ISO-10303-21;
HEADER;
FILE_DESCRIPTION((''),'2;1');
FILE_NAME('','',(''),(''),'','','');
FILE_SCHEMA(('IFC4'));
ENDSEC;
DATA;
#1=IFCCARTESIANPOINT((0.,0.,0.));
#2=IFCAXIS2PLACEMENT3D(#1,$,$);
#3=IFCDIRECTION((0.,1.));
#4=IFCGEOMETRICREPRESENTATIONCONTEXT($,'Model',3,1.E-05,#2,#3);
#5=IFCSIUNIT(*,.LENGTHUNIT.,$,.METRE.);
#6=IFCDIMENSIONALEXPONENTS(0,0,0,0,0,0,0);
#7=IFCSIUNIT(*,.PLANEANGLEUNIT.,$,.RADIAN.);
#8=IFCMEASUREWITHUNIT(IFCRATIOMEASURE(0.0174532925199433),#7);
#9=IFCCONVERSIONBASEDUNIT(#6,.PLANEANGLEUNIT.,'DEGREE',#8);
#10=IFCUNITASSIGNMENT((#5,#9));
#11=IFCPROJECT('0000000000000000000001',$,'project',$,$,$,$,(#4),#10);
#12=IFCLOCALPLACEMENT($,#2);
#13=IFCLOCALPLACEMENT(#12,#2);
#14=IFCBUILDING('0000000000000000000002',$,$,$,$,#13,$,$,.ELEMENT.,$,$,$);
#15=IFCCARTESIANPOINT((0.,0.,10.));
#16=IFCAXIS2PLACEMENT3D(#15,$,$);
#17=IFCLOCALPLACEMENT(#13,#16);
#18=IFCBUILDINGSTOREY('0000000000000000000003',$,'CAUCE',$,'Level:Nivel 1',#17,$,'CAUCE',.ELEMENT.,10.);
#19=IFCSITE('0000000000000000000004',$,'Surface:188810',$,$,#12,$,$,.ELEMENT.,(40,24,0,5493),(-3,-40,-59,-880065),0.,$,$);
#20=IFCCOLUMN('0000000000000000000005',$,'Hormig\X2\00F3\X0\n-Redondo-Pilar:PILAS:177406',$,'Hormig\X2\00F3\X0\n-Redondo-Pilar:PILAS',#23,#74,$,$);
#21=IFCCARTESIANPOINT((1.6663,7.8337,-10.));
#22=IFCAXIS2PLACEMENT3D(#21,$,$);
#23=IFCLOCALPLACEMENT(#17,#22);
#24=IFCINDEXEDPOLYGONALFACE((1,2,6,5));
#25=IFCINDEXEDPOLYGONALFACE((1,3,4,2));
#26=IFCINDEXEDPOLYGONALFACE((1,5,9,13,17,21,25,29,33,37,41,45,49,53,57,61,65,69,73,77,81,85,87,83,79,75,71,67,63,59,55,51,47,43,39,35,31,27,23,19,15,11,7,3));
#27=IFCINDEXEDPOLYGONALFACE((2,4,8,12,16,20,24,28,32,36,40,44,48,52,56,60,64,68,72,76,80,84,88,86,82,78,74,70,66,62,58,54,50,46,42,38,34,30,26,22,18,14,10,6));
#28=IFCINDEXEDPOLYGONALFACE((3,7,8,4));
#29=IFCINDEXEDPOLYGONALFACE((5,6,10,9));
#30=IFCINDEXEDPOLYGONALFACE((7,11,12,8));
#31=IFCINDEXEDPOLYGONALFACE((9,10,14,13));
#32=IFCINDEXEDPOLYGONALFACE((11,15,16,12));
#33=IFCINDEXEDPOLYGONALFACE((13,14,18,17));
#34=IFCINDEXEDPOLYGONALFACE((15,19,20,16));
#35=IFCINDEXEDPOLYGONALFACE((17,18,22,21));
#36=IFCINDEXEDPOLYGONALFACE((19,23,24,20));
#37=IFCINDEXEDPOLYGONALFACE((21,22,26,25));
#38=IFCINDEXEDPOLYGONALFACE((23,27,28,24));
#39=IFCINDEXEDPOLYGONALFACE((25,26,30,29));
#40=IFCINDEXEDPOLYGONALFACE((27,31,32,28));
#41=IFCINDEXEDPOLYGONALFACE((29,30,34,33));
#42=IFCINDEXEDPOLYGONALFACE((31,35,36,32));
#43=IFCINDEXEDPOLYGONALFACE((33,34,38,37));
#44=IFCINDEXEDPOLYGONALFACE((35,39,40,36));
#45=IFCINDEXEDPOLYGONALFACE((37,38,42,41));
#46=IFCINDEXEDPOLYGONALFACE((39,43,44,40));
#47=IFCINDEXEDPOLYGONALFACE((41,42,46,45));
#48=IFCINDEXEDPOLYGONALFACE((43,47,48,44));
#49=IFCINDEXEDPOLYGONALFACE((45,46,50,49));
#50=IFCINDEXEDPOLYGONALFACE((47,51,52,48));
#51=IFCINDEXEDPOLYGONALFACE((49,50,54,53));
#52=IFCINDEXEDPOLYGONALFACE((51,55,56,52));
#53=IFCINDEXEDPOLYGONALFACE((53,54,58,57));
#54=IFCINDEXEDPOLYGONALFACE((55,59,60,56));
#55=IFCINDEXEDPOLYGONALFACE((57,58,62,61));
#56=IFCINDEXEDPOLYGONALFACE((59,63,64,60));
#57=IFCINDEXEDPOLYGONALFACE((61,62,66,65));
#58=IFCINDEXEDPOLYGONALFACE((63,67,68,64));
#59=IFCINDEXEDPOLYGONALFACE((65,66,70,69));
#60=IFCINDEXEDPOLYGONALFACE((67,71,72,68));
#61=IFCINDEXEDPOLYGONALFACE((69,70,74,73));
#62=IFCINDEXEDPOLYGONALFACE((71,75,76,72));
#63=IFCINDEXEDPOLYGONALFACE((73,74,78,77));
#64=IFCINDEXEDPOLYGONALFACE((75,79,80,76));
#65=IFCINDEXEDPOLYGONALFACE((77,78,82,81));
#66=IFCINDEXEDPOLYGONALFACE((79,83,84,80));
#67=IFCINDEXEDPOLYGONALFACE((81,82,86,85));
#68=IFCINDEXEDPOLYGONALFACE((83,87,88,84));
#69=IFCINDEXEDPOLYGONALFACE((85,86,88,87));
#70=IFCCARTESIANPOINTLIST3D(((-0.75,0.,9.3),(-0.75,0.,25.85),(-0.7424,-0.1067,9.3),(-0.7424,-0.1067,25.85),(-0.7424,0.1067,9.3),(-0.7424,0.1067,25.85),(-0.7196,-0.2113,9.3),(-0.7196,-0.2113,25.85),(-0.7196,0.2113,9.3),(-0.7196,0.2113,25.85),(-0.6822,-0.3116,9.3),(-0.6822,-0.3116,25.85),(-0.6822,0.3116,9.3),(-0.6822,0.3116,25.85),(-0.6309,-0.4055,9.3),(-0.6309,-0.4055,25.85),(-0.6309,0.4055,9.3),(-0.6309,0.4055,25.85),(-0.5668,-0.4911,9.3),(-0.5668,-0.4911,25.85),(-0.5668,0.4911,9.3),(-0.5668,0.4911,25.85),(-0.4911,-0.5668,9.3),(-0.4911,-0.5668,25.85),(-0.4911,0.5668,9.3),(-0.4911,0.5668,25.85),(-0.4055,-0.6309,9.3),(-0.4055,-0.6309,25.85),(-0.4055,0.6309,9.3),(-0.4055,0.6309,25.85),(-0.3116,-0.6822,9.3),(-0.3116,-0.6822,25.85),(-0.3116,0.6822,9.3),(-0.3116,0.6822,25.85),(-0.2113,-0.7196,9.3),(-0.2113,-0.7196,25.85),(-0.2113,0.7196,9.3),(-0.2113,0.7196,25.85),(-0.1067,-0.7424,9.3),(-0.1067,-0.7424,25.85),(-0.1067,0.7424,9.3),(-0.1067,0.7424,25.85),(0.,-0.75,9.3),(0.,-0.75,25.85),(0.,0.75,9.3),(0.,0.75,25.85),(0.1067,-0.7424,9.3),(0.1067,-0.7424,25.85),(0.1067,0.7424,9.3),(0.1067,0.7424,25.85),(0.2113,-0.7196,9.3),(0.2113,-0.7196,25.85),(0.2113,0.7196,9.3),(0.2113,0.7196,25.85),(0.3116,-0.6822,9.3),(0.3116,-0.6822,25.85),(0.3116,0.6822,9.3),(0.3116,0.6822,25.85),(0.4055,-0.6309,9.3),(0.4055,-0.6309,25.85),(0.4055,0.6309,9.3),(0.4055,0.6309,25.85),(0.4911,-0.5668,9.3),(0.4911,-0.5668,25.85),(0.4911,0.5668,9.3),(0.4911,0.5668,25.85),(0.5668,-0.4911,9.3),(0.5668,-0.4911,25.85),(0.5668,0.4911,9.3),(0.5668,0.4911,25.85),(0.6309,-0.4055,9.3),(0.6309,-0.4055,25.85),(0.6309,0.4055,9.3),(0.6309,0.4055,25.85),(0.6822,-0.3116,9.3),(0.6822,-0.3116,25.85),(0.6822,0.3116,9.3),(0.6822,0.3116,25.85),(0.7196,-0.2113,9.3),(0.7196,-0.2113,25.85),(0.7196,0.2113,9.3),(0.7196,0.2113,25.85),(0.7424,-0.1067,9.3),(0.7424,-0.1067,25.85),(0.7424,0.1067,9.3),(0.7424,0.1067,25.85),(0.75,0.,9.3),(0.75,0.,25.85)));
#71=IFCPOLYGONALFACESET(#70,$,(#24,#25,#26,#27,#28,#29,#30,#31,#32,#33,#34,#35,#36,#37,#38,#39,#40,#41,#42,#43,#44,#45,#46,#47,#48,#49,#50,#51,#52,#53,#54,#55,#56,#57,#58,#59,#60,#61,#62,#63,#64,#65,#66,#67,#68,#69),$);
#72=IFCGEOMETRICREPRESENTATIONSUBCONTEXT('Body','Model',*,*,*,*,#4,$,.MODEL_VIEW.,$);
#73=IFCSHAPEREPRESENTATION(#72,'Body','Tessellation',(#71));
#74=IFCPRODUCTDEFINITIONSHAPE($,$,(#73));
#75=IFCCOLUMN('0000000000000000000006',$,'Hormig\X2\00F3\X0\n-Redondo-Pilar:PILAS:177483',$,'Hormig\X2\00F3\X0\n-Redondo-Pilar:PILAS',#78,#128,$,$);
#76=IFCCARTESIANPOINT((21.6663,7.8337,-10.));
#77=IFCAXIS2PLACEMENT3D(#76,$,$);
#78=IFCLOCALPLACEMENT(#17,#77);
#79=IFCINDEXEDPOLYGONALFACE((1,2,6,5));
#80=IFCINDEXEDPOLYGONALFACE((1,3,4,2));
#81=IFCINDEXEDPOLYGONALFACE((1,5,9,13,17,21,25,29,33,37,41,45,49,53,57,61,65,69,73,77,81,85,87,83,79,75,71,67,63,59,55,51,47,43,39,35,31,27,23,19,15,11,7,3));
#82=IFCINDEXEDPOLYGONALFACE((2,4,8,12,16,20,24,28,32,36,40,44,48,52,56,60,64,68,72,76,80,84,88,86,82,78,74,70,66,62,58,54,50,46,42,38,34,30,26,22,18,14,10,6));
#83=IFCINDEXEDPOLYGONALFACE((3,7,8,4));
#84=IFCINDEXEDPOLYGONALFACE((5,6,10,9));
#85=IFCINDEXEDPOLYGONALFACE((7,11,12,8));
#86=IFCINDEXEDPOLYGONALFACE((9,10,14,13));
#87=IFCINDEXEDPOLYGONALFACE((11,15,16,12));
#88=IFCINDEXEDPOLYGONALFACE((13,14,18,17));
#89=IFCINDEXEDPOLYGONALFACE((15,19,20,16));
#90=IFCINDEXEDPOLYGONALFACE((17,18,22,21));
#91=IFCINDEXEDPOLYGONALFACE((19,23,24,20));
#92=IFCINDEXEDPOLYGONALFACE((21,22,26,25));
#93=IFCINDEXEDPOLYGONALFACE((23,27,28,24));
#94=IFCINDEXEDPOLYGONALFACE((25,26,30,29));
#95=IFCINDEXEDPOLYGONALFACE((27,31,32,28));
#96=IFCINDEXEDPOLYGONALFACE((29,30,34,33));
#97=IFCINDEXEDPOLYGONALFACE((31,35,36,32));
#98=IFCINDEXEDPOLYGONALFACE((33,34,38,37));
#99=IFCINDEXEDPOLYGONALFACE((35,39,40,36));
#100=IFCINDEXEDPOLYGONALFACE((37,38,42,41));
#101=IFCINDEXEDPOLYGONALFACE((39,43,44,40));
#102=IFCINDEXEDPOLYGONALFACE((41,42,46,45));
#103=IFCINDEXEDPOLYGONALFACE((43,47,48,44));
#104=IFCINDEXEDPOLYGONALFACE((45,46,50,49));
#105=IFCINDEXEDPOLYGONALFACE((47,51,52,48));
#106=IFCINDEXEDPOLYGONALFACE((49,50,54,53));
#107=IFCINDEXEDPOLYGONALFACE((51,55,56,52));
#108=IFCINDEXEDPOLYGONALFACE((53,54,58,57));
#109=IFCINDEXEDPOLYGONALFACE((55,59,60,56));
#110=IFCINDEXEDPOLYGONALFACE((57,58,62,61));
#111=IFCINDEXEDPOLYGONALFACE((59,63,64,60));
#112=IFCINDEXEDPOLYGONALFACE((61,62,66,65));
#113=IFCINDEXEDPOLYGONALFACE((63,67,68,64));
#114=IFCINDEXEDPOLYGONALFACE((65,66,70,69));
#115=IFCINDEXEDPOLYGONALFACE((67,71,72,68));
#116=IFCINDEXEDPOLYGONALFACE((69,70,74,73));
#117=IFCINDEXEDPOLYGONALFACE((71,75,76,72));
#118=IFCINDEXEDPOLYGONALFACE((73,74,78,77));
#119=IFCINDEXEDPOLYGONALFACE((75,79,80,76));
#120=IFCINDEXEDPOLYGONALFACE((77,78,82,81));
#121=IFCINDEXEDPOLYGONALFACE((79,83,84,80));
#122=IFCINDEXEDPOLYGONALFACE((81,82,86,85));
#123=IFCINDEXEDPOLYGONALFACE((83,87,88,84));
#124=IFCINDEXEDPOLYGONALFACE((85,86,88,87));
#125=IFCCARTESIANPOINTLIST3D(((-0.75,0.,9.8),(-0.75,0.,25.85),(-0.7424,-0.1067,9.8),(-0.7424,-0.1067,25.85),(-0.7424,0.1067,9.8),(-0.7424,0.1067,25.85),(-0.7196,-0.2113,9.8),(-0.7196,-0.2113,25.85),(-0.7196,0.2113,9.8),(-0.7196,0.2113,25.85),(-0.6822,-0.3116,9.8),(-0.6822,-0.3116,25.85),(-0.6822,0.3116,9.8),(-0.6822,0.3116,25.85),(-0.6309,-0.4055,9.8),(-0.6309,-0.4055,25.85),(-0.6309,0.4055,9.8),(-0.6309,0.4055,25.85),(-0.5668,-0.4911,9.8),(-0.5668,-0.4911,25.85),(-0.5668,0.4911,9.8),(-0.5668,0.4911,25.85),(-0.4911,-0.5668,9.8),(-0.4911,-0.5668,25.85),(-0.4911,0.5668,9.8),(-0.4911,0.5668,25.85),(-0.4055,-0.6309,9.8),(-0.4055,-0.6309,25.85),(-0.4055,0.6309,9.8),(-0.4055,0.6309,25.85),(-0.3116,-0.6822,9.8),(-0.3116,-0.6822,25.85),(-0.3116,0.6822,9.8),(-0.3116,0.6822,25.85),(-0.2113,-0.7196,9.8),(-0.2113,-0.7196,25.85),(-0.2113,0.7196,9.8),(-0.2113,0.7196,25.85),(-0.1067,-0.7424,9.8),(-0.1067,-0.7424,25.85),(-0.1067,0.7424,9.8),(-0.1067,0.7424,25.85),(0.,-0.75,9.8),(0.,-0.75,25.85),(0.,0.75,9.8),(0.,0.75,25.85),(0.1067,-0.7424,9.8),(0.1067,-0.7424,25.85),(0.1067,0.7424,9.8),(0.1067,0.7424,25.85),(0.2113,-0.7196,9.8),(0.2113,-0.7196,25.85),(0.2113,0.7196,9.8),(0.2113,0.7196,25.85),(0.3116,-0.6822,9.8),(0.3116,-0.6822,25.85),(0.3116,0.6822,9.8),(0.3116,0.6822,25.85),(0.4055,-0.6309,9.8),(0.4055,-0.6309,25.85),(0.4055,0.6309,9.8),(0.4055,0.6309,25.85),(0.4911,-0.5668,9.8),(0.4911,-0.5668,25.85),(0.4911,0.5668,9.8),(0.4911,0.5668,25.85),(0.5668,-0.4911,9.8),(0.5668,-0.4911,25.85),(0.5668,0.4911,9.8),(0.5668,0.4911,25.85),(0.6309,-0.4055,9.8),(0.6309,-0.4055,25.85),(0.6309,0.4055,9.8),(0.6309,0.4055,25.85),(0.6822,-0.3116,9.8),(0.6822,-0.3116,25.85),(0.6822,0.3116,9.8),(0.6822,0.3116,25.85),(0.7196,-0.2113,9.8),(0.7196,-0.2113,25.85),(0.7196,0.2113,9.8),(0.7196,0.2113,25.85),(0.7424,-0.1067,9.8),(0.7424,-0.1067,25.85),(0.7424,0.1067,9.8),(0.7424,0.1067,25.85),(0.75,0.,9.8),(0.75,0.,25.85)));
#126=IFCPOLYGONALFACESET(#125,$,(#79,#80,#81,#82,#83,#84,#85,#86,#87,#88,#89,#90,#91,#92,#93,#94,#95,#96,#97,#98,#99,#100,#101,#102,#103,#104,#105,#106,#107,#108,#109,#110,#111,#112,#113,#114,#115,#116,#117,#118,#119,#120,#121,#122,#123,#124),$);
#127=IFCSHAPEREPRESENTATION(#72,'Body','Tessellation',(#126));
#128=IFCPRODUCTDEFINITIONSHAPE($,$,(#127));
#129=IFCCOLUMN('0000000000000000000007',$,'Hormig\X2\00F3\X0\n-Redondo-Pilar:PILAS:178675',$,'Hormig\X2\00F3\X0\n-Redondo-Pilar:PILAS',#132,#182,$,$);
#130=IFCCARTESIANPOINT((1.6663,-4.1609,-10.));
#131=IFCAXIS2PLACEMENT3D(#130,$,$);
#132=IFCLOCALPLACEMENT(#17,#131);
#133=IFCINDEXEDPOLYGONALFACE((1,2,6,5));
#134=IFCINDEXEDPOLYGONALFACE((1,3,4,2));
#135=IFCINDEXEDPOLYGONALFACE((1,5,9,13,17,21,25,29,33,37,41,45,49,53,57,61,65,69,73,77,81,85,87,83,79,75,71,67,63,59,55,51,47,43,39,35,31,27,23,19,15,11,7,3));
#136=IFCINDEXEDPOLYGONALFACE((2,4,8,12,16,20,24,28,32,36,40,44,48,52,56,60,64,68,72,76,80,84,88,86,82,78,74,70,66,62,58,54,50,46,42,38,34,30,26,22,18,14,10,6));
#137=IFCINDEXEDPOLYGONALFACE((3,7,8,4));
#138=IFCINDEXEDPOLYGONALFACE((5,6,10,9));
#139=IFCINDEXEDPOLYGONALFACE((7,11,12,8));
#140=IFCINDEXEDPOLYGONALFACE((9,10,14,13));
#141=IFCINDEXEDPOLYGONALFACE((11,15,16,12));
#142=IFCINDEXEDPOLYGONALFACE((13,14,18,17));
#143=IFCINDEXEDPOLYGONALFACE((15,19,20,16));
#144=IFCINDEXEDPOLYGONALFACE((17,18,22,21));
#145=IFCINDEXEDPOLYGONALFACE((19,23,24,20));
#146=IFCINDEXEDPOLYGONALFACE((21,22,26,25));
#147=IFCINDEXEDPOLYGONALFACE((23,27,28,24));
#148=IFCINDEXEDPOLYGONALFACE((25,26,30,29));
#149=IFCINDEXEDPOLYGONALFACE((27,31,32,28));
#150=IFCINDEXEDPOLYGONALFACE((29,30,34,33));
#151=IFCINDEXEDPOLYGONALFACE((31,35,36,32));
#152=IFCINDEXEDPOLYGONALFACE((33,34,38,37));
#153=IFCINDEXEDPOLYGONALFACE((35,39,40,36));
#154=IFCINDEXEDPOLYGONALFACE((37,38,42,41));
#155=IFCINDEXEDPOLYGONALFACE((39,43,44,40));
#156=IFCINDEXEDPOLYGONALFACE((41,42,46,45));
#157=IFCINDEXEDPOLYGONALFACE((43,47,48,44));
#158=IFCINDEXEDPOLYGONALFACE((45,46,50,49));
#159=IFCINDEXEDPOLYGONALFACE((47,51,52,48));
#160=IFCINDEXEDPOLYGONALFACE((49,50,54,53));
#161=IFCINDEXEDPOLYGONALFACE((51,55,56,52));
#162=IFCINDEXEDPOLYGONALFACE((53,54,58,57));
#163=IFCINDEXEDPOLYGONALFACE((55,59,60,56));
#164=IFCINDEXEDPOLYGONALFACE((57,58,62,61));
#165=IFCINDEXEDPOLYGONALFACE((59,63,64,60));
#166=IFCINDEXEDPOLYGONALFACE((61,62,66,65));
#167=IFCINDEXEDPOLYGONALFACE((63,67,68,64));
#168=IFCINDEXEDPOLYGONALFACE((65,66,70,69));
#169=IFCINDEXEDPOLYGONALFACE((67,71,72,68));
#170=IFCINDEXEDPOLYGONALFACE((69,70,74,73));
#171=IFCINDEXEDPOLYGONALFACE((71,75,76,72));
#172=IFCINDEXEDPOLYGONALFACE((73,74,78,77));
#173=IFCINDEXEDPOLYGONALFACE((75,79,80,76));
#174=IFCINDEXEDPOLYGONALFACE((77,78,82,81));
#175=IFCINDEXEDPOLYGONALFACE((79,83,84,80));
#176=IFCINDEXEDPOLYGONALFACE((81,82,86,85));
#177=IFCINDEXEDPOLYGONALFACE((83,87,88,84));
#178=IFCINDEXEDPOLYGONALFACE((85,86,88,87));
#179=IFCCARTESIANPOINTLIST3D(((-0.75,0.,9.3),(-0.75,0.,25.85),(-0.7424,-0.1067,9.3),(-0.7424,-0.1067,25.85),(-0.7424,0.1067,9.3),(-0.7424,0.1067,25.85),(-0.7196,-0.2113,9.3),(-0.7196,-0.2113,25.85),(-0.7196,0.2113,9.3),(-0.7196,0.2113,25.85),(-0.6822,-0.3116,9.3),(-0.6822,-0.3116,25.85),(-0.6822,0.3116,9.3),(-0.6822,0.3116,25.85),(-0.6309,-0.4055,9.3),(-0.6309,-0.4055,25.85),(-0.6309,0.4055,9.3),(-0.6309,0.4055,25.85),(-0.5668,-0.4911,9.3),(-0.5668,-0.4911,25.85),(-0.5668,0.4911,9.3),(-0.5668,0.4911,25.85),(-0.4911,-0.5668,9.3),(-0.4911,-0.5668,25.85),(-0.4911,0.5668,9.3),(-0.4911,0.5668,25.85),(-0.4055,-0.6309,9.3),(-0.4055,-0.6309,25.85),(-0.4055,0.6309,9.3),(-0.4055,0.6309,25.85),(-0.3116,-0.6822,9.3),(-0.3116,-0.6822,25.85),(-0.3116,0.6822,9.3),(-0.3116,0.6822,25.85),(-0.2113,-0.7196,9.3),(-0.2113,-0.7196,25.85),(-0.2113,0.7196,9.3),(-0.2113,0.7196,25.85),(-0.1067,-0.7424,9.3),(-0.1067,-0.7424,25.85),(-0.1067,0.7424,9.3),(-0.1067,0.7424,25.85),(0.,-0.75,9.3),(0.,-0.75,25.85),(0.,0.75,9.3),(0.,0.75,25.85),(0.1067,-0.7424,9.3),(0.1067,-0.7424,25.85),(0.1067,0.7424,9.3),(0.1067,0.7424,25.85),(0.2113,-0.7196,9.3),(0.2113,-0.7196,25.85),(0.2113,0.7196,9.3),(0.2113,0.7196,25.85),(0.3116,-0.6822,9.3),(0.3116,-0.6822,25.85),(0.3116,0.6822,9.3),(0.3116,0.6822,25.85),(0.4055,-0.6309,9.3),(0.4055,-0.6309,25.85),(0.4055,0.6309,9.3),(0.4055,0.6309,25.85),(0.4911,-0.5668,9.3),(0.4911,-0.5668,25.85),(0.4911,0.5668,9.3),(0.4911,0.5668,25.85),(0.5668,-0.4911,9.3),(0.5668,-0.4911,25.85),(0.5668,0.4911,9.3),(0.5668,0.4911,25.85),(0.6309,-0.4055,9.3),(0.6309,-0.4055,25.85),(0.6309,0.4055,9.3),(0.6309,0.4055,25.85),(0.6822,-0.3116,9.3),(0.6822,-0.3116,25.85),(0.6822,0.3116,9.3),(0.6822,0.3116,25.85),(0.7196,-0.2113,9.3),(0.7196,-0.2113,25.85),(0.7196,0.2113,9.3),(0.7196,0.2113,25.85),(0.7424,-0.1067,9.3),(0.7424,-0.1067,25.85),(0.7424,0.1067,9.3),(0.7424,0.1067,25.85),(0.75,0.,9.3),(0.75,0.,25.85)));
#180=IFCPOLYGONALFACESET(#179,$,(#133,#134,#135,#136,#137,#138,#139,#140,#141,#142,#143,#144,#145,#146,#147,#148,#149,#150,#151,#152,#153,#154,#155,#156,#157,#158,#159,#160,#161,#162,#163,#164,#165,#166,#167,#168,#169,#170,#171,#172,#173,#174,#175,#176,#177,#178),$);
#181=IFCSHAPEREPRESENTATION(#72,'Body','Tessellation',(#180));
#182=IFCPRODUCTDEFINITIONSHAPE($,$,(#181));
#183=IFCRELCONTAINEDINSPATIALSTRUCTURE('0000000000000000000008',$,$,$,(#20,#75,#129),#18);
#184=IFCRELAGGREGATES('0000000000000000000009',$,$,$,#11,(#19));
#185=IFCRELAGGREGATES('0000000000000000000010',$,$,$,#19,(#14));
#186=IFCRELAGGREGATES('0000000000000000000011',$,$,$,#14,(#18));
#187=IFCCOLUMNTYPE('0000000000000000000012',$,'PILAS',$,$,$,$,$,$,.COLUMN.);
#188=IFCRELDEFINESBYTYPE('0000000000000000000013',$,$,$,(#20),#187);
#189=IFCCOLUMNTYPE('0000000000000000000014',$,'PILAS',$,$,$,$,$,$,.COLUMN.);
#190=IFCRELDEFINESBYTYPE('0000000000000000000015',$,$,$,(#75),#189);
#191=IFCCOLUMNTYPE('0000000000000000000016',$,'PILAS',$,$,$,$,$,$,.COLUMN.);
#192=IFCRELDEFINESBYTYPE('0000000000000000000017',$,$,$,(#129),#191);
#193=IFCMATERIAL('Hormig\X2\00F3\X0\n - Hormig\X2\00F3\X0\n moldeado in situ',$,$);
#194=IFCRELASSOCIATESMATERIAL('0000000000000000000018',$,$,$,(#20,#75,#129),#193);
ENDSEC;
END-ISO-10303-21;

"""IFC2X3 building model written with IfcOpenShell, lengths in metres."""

from ifc_helpers import new_model, entity, si_unit, converted_unit, direction, frame, frame_2d, origin, place, context, subcontext, project, spatial, circle, extrude, source, transform, mapped, material, type_object, type_shapes, element, save


model = new_model("IFC2X3")

# Units and contexts
model_context = context("Model", 3, precision=1e-05, world=origin(), true_north=direction((0.0, 1.0)))
body_context = subcontext(model_context, "Body", "Model", "MODEL_VIEW")
ifc_project = project(units=[si_unit("LENGTHUNIT", "METRE"), converted_unit("PLANEANGLEUNIT", "DEGREE", entity("IfcRatioMeasure", 0.0174532925199433), si_unit("PLANEANGLEUNIT", "RADIAN"), dimensions=[0, 0, 0, 0, 0, 0, 0])], contexts=[model_context])

# Site, building, storey
site_placement = place(None, origin())
site = spatial("IfcSite", under=ifc_project, at=site_placement, Name="Surface:188810", CompositionType="ELEMENT", RefLatitude=(40, 24, 0, 5493), RefLongitude=(-3, -40, -59, -880065), RefElevation=0.0)
building_placement = place(site_placement, origin())
building = spatial("IfcBuilding", under=site, at=building_placement, CompositionType="ELEMENT")
storey_placement = place(building_placement, frame((0.0, 0.0, 10.0)))
storey = spatial("IfcBuildingStorey", under=building, at=storey_placement, Name="CAUCE", ObjectType="Level:Nivel 1", LongName="CAUCE", CompositionType="ELEMENT", Elevation=10.0)

# Columns
ifc_material_1 = material(Name="Hormigón - Hormigón moldeado in situ")
column_type_1 = type_object("IfcColumnType", Name="PILAS", PredefinedType="COLUMN")
shared_shape_1 = source(origin(), body_context, "Body", "SweptSolid", [
    extrude(circle(Radius=0.75, at=frame_2d((0.0, 0.0), x_axis=(1.0, 0.0))), frame((0.0, 0.0, 9.3)), (0.0, 0.0, 1.0), 16.55),
])
type_shapes(column_type_1, [shared_shape_1])
column_1_placement = place(storey_placement, frame((1.6663, 7.8337, -10.0)))
element("IfcColumn", 1, at=column_1_placement, inside=storey, type_object=column_type_1, material=ifc_material_1, Name="Hormigón-Redondo-Pilar:PILAS:177406", ObjectType="Hormigón-Redondo-Pilar:PILAS", context=body_context, shape_type="MappedRepresentation", body=[
    mapped(shared_shape_1, transform((0.0, 0.0, 0.0), scale=1.0)),
])
column_type_2 = type_object("IfcColumnType", Name="PILAS", PredefinedType="COLUMN")
shared_shape_2 = source(origin(), body_context, "Body", "SweptSolid", [
    extrude(circle(Radius=0.75, at=frame_2d((0.0, 0.0), x_axis=(1.0, 0.0))), frame((0.0, 0.0, 9.8)), (0.0, 0.0, 1.0), 16.05),
])
type_shapes(column_type_2, [shared_shape_2])
column_2_placement = place(storey_placement, frame((21.6663, 7.8337, -10.0)))
element("IfcColumn", 2, at=column_2_placement, inside=storey, type_object=column_type_2, material=ifc_material_1, Name="Hormigón-Redondo-Pilar:PILAS:177483", ObjectType="Hormigón-Redondo-Pilar:PILAS", context=body_context, shape_type="MappedRepresentation", body=[
    mapped(shared_shape_2, transform((0.0, 0.0, 0.0), scale=1.0)),
])
column_type_3 = type_object("IfcColumnType", Name="PILAS", PredefinedType="COLUMN")
shared_shape_3 = source(origin(), body_context, "Body", "SweptSolid", [
    extrude(circle(Radius=0.75, at=frame_2d((0.0, 0.0), x_axis=(1.0, 0.0))), frame((0.0, 0.0, 9.3), z_axis=(0.0, 0.0, 1.0), x_axis=(-1.0, 0.0, 0.0)), (0.0, 0.0, 1.0), 16.55),
])
type_shapes(column_type_3, [shared_shape_3])
column_3_placement = place(storey_placement, frame((1.6663, -4.1609, -10.0)))
element("IfcColumn", 3, at=column_3_placement, inside=storey, type_object=column_type_3, material=ifc_material_1, Name="Hormigón-Redondo-Pilar:PILAS:178675", ObjectType="Hormigón-Redondo-Pilar:PILAS", context=body_context, shape_type="MappedRepresentation", body=[
    mapped(shared_shape_3, transform((0.0, 0.0, 0.0), scale=1.0)),
])

save(model, "model.ifc")
